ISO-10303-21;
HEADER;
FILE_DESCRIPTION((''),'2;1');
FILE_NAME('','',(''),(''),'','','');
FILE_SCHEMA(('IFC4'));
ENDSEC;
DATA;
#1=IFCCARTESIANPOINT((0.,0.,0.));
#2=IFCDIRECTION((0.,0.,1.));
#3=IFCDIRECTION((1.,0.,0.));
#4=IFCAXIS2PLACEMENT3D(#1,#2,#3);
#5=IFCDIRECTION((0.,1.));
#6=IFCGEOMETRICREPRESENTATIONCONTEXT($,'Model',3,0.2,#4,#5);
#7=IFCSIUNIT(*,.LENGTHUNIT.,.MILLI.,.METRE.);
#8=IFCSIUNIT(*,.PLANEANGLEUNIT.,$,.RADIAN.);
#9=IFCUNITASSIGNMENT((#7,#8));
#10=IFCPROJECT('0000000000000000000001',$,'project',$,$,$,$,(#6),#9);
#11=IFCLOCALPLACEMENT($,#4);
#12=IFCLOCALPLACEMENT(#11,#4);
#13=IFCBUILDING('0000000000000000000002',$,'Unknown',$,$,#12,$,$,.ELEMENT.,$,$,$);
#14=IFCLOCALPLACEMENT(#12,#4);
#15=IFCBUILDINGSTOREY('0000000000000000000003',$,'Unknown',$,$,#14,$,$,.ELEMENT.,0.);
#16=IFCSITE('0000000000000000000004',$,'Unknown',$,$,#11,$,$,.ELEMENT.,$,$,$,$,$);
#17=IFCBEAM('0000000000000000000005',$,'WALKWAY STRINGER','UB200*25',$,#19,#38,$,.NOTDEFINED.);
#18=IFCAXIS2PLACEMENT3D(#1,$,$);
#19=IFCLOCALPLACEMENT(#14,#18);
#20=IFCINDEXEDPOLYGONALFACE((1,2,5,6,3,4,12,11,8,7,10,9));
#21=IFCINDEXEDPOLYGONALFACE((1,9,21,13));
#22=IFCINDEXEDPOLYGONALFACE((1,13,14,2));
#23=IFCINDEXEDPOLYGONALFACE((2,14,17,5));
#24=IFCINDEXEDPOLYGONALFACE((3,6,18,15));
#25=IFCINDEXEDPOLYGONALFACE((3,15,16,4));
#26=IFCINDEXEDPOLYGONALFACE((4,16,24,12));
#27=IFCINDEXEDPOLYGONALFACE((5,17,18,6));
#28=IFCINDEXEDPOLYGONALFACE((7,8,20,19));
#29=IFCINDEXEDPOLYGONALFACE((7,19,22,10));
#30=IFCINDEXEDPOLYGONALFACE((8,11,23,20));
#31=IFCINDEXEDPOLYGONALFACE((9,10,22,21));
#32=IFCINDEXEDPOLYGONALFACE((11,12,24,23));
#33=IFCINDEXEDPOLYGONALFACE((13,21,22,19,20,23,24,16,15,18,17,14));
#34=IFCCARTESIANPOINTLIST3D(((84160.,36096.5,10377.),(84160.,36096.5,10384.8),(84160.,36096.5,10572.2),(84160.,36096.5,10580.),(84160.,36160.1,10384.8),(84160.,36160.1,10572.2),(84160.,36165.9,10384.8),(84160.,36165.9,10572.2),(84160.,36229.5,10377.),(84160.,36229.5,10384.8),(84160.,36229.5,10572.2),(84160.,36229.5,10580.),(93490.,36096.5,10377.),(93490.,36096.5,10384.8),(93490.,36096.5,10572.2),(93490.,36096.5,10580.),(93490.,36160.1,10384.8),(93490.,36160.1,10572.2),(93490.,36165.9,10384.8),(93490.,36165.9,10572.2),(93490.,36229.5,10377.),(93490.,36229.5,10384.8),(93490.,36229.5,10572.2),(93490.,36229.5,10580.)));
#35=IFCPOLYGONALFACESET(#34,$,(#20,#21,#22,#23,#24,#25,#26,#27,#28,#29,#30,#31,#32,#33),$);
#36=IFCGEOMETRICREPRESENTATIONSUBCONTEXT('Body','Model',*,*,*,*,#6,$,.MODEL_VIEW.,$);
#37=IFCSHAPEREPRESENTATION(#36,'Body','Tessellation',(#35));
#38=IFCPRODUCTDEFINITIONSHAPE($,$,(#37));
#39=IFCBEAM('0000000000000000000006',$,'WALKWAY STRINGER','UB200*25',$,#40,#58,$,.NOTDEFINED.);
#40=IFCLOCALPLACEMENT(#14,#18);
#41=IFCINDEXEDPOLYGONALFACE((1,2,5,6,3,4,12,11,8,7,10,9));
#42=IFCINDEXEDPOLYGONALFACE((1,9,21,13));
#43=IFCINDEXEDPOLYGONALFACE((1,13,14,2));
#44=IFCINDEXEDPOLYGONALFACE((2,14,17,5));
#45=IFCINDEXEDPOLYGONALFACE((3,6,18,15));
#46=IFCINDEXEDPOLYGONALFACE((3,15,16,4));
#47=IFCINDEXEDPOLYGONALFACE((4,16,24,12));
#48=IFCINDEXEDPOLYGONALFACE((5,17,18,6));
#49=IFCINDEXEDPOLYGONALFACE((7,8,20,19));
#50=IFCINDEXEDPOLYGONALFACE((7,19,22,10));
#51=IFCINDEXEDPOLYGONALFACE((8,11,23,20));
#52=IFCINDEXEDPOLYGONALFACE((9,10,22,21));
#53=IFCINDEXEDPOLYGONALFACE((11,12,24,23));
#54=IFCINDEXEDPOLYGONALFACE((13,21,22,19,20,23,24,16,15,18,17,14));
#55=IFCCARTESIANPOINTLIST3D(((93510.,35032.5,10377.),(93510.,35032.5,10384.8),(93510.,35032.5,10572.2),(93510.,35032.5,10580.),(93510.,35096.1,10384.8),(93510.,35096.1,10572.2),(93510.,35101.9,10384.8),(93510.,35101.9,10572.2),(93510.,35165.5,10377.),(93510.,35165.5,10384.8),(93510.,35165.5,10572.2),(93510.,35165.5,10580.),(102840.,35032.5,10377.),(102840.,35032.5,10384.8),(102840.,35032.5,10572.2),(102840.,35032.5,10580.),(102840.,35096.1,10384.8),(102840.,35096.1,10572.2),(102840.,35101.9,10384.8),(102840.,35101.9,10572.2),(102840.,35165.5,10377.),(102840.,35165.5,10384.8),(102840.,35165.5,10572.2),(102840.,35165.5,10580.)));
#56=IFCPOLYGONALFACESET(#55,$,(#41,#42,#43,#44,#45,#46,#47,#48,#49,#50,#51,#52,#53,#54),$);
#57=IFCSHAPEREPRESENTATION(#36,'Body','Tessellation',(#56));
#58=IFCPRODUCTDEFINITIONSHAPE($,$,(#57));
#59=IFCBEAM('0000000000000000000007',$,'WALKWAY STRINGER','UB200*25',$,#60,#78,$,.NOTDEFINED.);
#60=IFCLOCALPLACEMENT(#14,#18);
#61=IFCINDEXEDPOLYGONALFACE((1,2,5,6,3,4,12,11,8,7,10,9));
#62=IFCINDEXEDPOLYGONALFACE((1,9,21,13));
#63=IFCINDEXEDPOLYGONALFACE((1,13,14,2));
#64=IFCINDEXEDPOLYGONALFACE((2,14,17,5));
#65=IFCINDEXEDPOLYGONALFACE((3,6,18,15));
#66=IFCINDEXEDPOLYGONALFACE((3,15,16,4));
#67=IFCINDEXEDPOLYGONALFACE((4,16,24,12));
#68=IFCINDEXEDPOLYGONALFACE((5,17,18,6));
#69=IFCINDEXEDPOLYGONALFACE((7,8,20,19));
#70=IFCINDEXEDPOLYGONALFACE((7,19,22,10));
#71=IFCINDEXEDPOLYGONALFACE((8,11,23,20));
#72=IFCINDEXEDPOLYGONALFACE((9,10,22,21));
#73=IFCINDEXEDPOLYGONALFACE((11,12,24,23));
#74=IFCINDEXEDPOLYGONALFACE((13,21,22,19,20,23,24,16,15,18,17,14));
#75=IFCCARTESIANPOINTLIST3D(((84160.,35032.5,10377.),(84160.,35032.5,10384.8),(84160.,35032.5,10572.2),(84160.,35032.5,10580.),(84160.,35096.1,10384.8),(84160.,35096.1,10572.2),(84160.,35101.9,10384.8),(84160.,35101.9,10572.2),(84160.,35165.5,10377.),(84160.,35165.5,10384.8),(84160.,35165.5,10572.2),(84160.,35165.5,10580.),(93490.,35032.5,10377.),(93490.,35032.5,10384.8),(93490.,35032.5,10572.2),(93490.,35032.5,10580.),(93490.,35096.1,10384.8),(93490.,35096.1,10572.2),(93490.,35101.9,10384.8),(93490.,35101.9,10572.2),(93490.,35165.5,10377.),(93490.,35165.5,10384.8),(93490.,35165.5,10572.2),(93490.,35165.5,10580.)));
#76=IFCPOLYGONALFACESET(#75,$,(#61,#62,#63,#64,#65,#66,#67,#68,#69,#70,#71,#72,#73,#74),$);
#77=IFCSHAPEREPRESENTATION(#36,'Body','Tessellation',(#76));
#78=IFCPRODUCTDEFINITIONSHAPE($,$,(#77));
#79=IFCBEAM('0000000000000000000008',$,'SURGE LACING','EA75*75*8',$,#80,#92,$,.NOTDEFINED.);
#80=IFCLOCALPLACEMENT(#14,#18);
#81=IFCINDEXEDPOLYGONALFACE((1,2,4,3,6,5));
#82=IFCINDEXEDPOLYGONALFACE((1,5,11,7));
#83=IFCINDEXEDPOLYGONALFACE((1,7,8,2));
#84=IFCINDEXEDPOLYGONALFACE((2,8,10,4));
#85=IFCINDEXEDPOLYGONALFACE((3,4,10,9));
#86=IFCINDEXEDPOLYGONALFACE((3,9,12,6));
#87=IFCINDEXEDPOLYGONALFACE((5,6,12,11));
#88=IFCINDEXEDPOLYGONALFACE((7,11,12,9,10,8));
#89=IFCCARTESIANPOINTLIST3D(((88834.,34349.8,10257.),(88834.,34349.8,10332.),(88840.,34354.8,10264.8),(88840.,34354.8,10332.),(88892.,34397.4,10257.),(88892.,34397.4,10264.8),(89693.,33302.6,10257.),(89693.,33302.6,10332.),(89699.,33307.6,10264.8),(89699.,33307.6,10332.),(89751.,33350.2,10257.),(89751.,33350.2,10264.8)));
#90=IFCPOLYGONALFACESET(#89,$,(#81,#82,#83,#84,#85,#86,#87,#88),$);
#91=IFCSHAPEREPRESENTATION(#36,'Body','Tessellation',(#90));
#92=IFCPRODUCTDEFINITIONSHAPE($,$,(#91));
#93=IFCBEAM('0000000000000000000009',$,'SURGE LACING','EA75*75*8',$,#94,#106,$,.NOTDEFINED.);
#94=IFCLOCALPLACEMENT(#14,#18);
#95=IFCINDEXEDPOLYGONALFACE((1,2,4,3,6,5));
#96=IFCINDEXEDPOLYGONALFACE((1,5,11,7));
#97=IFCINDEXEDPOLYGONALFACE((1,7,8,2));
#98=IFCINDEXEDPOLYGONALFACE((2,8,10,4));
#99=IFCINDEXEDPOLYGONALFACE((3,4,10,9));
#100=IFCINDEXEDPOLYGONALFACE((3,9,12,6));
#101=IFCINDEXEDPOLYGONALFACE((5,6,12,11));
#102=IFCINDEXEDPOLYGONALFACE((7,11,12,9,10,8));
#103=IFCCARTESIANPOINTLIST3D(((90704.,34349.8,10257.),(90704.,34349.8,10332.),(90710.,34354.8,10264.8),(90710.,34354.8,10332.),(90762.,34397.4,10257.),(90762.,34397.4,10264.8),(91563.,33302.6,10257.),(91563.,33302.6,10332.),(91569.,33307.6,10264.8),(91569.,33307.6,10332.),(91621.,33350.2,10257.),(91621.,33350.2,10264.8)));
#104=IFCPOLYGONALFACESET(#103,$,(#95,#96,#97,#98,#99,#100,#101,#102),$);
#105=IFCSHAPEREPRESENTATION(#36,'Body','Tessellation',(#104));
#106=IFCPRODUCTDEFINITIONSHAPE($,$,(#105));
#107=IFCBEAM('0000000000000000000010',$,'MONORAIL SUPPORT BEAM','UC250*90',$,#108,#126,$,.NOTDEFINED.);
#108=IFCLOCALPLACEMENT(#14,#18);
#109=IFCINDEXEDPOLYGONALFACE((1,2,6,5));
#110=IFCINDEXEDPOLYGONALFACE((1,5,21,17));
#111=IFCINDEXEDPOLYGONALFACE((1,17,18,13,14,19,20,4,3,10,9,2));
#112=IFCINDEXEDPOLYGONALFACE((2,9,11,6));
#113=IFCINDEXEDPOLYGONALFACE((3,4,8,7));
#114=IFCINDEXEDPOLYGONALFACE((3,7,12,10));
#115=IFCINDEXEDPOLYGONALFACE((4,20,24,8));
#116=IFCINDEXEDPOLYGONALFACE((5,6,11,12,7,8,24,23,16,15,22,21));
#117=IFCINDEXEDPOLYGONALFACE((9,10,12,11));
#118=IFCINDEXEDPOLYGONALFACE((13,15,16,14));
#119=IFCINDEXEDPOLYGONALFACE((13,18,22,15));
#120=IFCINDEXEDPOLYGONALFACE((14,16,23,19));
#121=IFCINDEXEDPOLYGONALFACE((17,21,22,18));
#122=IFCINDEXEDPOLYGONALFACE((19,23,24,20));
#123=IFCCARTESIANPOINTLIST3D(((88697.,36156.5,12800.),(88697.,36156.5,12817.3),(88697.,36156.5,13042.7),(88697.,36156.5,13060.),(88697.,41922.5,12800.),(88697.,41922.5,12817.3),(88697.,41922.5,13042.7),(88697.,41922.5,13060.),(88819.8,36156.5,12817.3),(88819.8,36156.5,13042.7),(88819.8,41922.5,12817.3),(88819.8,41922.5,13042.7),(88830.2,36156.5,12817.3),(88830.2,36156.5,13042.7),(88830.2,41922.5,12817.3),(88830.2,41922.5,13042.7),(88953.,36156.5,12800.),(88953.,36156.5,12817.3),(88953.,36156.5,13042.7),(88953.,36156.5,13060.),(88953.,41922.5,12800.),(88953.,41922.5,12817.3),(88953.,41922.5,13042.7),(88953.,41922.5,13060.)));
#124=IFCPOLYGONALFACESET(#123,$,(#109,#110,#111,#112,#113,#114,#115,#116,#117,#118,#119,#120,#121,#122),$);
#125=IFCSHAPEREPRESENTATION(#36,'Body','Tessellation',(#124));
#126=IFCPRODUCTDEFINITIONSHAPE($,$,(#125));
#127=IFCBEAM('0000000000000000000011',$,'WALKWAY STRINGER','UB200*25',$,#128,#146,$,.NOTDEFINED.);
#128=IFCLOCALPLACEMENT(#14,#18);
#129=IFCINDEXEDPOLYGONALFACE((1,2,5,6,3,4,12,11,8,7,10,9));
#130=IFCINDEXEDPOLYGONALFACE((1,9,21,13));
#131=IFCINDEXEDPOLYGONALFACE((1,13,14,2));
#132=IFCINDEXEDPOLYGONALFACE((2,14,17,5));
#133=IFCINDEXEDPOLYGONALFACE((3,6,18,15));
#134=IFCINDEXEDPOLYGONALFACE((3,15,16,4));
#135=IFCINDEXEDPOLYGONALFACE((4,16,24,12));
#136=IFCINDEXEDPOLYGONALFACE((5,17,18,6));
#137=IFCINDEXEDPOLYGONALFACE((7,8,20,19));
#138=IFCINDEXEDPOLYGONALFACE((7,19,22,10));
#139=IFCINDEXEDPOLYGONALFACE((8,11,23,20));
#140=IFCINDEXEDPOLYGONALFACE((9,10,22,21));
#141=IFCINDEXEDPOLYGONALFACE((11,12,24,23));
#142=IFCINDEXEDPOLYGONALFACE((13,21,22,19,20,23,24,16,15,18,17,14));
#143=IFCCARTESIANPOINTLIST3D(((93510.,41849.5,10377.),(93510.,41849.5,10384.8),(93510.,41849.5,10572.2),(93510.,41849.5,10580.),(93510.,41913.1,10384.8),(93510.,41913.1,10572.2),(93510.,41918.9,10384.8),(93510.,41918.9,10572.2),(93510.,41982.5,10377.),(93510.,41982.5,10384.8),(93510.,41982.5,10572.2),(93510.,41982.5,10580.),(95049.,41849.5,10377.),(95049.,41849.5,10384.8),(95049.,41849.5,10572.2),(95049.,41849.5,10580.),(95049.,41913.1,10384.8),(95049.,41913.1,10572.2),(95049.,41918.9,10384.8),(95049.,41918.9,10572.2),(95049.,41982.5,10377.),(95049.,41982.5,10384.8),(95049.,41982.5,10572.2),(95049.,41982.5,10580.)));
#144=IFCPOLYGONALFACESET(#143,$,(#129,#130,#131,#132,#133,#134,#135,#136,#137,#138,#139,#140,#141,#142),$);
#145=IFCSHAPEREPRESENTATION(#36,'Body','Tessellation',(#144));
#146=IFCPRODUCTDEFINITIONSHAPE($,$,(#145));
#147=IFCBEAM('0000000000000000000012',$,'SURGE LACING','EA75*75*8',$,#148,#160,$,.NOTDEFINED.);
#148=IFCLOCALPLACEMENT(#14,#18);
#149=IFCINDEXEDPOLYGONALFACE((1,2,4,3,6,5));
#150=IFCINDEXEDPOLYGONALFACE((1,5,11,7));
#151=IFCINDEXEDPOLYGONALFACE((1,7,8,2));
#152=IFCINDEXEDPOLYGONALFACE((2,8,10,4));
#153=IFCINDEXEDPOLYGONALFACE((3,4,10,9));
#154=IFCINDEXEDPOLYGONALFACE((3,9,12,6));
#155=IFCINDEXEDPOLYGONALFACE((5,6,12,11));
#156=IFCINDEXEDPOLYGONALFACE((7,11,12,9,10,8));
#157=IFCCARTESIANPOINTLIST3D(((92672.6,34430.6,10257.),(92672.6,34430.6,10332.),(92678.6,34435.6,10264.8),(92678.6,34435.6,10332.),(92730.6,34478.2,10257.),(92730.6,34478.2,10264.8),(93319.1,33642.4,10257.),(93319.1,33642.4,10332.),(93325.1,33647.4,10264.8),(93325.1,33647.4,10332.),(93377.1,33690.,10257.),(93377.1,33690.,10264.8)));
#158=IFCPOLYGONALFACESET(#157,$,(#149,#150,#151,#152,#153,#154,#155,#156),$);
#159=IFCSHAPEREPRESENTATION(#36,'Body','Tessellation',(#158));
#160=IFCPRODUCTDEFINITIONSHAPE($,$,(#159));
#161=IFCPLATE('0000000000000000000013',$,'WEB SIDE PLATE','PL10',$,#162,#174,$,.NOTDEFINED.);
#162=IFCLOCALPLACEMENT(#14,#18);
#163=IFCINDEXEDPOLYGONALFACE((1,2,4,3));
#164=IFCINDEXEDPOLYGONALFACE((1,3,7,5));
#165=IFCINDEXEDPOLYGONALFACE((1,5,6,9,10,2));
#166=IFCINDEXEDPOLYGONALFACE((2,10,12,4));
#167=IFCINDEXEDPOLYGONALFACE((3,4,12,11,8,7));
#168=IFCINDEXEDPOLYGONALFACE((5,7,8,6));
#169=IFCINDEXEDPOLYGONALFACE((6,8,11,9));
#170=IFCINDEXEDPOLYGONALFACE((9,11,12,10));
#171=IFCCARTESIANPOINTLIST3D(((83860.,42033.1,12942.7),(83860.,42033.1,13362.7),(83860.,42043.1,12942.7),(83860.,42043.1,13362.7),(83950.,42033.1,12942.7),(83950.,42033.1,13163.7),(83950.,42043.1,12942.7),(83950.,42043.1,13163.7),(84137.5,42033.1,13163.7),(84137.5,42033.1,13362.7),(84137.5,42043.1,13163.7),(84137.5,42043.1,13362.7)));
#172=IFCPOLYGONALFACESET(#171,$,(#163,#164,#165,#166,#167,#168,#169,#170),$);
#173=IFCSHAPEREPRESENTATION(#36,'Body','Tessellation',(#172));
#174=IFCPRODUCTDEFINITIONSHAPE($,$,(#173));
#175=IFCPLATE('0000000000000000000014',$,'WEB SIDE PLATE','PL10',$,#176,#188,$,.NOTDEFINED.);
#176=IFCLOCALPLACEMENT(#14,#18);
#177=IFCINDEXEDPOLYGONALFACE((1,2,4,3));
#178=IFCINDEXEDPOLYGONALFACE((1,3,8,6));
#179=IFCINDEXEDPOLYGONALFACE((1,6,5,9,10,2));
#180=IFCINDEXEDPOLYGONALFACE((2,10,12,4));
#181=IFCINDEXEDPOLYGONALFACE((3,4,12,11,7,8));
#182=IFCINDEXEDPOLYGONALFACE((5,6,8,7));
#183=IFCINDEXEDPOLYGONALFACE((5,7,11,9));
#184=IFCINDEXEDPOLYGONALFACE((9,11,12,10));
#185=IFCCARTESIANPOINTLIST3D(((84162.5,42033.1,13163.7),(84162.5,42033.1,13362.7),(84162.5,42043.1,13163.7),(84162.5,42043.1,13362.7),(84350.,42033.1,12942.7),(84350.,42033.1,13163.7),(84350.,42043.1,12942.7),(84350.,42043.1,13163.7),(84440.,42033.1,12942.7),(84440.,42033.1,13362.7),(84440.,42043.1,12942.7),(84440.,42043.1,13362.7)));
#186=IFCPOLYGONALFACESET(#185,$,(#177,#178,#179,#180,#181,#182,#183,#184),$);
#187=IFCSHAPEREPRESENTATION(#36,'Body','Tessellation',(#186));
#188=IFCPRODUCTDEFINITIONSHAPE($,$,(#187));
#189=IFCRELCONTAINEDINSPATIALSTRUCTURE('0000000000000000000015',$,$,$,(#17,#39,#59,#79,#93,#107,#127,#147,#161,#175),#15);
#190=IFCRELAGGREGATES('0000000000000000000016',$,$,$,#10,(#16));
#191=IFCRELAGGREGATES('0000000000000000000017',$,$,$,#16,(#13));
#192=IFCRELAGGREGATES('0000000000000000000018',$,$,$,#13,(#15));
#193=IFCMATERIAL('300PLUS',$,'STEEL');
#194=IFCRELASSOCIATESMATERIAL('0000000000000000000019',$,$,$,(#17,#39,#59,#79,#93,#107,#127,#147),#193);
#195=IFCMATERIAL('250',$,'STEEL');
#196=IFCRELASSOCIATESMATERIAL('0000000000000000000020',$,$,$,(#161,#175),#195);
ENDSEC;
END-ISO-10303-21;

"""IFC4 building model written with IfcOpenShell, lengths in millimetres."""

from ifc_helpers import new_model, si_unit, direction, frame, origin_with_axes, place, context, subcontext, project, spatial, line, indexed_curve, outline, extrude, material, element, save


model = new_model("IFC4")

# Units and contexts
model_context = context("Model", 3, precision=0.2, world=origin_with_axes(), true_north=direction((0.0, 1.0)))
body_context = subcontext(model_context, "Body", "Model", "MODEL_VIEW")
ifc_project = project(units=[si_unit("LENGTHUNIT", "METRE", prefix="MILLI"), si_unit("PLANEANGLEUNIT", "RADIAN")], contexts=[model_context])

# Site, building, storey
site_placement = place(None, origin_with_axes())
site = spatial("IfcSite", under=ifc_project, at=site_placement, Name="Unknown", CompositionType="ELEMENT")
building_placement = place(site_placement, origin_with_axes())
building = spatial("IfcBuilding", under=site, at=building_placement, Name="Unknown", CompositionType="ELEMENT")
storey_placement = place(building_placement, origin_with_axes())
storey = spatial("IfcBuildingStorey", under=building, at=storey_placement, Name="Unknown", CompositionType="ELEMENT", Elevation=0.0)

# Shared definitions
ifc_material_1 = material(Name="300PLUS", Category="STEEL")

# Beams
for number, where, z_axis, x_axis, name in (
    (1, (84160.0, 36163.0, 10478.5), (0.0, -1.0, 0.0), (1.0, 0.0, 0.0), "WALKWAY STRINGER"),
    (2, (93510.0, 35099.0, 10478.5), (0.0, -1.0, 0.0), (1.0, 0.0, 0.0), "WALKWAY STRINGER"),
    (3, (84160.0, 35099.0, 10478.5), (0.0, -1.0, 0.0), (1.0, 0.0, 0.0), "WALKWAY STRINGER"),
):
    element("IfcBeam", number, at=place(storey_placement, frame(where, z_axis=z_axis, x_axis=x_axis)), inside=storey, material=ifc_material_1, Name=name, Description="UB200*25", PredefinedType="NOTDEFINED", context=body_context, shape_type="SolidModel", body=[
        extrude(outline(indexed_curve([(-66.5, -101.5), (66.5, -101.5), (66.5, -93.7), (2.9, -93.7), (2.9, 93.7), (66.5, 93.7), (66.5, 101.5), (-66.5, 101.5), (-66.5, 93.7), (-2.9, 93.7), (-2.9, -93.7), (-66.5, -93.7)], segments=[line(1, 2, 3, 4, 5, 6, 7, 8, 9, 10, 11, 12, 1)])), frame((0.0, 0.0, 0.0), z_axis=(-1.0, 0.0, 0.0), x_axis=(0.0, 0.0, 1.0)), (0.0, 0.0, -1.0), 9330.0),
    ])
for number, where, z_axis, x_axis, name in (
    (4, (88863.0, 34373.6, 10294.5), (0.0, 0.0, 1.0), (0.63421, -0.773161, 0.0), "SURGE LACING"),
    (5, (90733.0, 34373.6, 10294.5), (0.0, 0.0, 1.0), (0.63421, -0.773161, 0.0), "SURGE LACING"),
):
    element("IfcBeam", number, at=place(storey_placement, frame(where, z_axis=z_axis, x_axis=x_axis)), inside=storey, material=ifc_material_1, Name=name, Description="EA75*75*8", PredefinedType="NOTDEFINED", context=body_context, shape_type="SolidModel", body=[
        extrude(outline(indexed_curve([(-37.5, -37.5), (37.5, -37.5), (37.5, -29.7), (-29.7, -29.7), (-29.7, 37.5), (-37.5, 37.5)], segments=[line(1, 2, 3, 4, 5, 6, 1)])), frame((0.0, 0.0, 0.0), z_axis=(-1.0, 0.0, 0.0), x_axis=(0.0, 0.0, 1.0)), (0.0, 0.0, -1.0), 1354.4),
    ])
beam_1_placement = place(storey_placement, frame((88825.0, 36156.5, 12930.0), z_axis=(1.0, 0.0, 0.0), x_axis=(0.0, 1.0, 0.0)))
element("IfcBeam", 6, at=beam_1_placement, inside=storey, material=ifc_material_1, Name="MONORAIL SUPPORT BEAM", Description="UC250*90", PredefinedType="NOTDEFINED", context=body_context, shape_type="SolidModel", body=[
    extrude(outline(indexed_curve([(-128.0, -130.0), (128.0, -130.0), (128.0, -112.7), (5.2, -112.7), (5.2, 112.7), (128.0, 112.7), (128.0, 130.0), (-128.0, 130.0), (-128.0, 112.7), (-5.2, 112.7), (-5.2, -112.7), (-128.0, -112.7)], segments=[line(1, 2, 3, 4, 5, 6, 7, 8, 9, 10, 11, 12, 1)])), frame((0.0, 0.0, 0.0), z_axis=(-1.0, 0.0, 0.0), x_axis=(0.0, 0.0, 1.0)), (0.0, 0.0, -1.0), 5766.0),
])
beam_2_placement = place(storey_placement, frame((93510.0, 41916.0, 10478.5), z_axis=(0.0, -1.0, 0.0), x_axis=(1.0, 0.0, 0.0)))
element("IfcBeam", 7, at=beam_2_placement, inside=storey, material=ifc_material_1, Name="WALKWAY STRINGER", Description="UB200*25", PredefinedType="NOTDEFINED", context=body_context, shape_type="SolidModel", body=[
    extrude(outline(indexed_curve([(-66.5, -101.5), (66.5, -101.5), (66.5, -93.7), (2.9, -93.7), (2.9, 93.7), (66.5, 93.7), (66.5, 101.5), (-66.5, 101.5), (-66.5, 93.7), (-2.9, 93.7), (-2.9, -93.7), (-66.5, -93.7)], segments=[line(1, 2, 3, 4, 5, 6, 7, 8, 9, 10, 11, 12, 1)])), frame((0.0, 0.0, 0.0), z_axis=(-1.0, 0.0, 0.0), x_axis=(0.0, 0.0, 1.0)), (0.0, 0.0, -1.0), 1539.0),
])
beam_3_placement = place(storey_placement, frame((92701.6, 34454.4, 10294.5), z_axis=(0.0, 0.0, 1.0), x_axis=(0.634183, -0.773183, 0.0)))
element("IfcBeam", 8, at=beam_3_placement, inside=storey, material=ifc_material_1, Name="SURGE LACING", Description="EA75*75*8", PredefinedType="NOTDEFINED", context=body_context, shape_type="SolidModel", body=[
    extrude(outline(indexed_curve([(-37.5, -37.5), (37.5, -37.5), (37.5, -29.7), (-29.7, -29.7), (-29.7, 37.5), (-37.5, 37.5)], segments=[line(1, 2, 3, 4, 5, 6, 1)])), frame((0.0, 0.0, 0.0), z_axis=(-1.0, 0.0, 0.0), x_axis=(0.0, 0.0, 1.0)), (0.0, 0.0, -1.0), 1019.4),
])

# Plates
ifc_material_2 = material(Name="250", Category="STEEL")
plate_1_placement = place(storey_placement, frame((83950.0, 42038.1, 12942.7), z_axis=(0.0, -1.0, 0.0), x_axis=(0.0, 0.0, 1.0)))
element("IfcPlate", 9, at=plate_1_placement, inside=storey, material=ifc_material_2, Name="WEB SIDE PLATE", Description="PL10", PredefinedType="NOTDEFINED", context=body_context, shape_type="SolidModel", body=[
    extrude(outline(indexed_curve([(0.0, 0.0), (221.0, 0.0), (221.0, -187.5), (420.0, -187.5), (420.0, 90.0), (0.0, 90.0)], segments=[line(1, 2, 3, 4, 5, 6, 1)])), frame((0.0, 0.0, 5.0), z_axis=(0.0, 0.0, 1.0), x_axis=(1.0, 0.0, 0.0)), (0.0, 0.0, -1.0), 10.0),
])
plate_2_placement = place(storey_placement, frame((84440.0, 42038.1, 12942.7), z_axis=(0.0, -1.0, 0.0), x_axis=(0.0, 0.0, 1.0)))
element("IfcPlate", 10, at=plate_2_placement, inside=storey, material=ifc_material_2, Name="WEB SIDE PLATE", Description="PL10", PredefinedType="NOTDEFINED", context=body_context, shape_type="SolidModel", body=[
    extrude(outline(indexed_curve([(0.0, 0.0), (420.0, 0.0), (420.0, 277.5), (221.0, 277.5), (221.0, 90.0), (0.0, 90.0)], segments=[line(1, 2, 3, 4, 5, 6, 1)])), frame((0.0, 0.0, 5.0), z_axis=(0.0, 0.0, 1.0), x_axis=(1.0, 0.0, 0.0)), (0.0, 0.0, -1.0), 10.0),
])

save(model, "model.ifc")
